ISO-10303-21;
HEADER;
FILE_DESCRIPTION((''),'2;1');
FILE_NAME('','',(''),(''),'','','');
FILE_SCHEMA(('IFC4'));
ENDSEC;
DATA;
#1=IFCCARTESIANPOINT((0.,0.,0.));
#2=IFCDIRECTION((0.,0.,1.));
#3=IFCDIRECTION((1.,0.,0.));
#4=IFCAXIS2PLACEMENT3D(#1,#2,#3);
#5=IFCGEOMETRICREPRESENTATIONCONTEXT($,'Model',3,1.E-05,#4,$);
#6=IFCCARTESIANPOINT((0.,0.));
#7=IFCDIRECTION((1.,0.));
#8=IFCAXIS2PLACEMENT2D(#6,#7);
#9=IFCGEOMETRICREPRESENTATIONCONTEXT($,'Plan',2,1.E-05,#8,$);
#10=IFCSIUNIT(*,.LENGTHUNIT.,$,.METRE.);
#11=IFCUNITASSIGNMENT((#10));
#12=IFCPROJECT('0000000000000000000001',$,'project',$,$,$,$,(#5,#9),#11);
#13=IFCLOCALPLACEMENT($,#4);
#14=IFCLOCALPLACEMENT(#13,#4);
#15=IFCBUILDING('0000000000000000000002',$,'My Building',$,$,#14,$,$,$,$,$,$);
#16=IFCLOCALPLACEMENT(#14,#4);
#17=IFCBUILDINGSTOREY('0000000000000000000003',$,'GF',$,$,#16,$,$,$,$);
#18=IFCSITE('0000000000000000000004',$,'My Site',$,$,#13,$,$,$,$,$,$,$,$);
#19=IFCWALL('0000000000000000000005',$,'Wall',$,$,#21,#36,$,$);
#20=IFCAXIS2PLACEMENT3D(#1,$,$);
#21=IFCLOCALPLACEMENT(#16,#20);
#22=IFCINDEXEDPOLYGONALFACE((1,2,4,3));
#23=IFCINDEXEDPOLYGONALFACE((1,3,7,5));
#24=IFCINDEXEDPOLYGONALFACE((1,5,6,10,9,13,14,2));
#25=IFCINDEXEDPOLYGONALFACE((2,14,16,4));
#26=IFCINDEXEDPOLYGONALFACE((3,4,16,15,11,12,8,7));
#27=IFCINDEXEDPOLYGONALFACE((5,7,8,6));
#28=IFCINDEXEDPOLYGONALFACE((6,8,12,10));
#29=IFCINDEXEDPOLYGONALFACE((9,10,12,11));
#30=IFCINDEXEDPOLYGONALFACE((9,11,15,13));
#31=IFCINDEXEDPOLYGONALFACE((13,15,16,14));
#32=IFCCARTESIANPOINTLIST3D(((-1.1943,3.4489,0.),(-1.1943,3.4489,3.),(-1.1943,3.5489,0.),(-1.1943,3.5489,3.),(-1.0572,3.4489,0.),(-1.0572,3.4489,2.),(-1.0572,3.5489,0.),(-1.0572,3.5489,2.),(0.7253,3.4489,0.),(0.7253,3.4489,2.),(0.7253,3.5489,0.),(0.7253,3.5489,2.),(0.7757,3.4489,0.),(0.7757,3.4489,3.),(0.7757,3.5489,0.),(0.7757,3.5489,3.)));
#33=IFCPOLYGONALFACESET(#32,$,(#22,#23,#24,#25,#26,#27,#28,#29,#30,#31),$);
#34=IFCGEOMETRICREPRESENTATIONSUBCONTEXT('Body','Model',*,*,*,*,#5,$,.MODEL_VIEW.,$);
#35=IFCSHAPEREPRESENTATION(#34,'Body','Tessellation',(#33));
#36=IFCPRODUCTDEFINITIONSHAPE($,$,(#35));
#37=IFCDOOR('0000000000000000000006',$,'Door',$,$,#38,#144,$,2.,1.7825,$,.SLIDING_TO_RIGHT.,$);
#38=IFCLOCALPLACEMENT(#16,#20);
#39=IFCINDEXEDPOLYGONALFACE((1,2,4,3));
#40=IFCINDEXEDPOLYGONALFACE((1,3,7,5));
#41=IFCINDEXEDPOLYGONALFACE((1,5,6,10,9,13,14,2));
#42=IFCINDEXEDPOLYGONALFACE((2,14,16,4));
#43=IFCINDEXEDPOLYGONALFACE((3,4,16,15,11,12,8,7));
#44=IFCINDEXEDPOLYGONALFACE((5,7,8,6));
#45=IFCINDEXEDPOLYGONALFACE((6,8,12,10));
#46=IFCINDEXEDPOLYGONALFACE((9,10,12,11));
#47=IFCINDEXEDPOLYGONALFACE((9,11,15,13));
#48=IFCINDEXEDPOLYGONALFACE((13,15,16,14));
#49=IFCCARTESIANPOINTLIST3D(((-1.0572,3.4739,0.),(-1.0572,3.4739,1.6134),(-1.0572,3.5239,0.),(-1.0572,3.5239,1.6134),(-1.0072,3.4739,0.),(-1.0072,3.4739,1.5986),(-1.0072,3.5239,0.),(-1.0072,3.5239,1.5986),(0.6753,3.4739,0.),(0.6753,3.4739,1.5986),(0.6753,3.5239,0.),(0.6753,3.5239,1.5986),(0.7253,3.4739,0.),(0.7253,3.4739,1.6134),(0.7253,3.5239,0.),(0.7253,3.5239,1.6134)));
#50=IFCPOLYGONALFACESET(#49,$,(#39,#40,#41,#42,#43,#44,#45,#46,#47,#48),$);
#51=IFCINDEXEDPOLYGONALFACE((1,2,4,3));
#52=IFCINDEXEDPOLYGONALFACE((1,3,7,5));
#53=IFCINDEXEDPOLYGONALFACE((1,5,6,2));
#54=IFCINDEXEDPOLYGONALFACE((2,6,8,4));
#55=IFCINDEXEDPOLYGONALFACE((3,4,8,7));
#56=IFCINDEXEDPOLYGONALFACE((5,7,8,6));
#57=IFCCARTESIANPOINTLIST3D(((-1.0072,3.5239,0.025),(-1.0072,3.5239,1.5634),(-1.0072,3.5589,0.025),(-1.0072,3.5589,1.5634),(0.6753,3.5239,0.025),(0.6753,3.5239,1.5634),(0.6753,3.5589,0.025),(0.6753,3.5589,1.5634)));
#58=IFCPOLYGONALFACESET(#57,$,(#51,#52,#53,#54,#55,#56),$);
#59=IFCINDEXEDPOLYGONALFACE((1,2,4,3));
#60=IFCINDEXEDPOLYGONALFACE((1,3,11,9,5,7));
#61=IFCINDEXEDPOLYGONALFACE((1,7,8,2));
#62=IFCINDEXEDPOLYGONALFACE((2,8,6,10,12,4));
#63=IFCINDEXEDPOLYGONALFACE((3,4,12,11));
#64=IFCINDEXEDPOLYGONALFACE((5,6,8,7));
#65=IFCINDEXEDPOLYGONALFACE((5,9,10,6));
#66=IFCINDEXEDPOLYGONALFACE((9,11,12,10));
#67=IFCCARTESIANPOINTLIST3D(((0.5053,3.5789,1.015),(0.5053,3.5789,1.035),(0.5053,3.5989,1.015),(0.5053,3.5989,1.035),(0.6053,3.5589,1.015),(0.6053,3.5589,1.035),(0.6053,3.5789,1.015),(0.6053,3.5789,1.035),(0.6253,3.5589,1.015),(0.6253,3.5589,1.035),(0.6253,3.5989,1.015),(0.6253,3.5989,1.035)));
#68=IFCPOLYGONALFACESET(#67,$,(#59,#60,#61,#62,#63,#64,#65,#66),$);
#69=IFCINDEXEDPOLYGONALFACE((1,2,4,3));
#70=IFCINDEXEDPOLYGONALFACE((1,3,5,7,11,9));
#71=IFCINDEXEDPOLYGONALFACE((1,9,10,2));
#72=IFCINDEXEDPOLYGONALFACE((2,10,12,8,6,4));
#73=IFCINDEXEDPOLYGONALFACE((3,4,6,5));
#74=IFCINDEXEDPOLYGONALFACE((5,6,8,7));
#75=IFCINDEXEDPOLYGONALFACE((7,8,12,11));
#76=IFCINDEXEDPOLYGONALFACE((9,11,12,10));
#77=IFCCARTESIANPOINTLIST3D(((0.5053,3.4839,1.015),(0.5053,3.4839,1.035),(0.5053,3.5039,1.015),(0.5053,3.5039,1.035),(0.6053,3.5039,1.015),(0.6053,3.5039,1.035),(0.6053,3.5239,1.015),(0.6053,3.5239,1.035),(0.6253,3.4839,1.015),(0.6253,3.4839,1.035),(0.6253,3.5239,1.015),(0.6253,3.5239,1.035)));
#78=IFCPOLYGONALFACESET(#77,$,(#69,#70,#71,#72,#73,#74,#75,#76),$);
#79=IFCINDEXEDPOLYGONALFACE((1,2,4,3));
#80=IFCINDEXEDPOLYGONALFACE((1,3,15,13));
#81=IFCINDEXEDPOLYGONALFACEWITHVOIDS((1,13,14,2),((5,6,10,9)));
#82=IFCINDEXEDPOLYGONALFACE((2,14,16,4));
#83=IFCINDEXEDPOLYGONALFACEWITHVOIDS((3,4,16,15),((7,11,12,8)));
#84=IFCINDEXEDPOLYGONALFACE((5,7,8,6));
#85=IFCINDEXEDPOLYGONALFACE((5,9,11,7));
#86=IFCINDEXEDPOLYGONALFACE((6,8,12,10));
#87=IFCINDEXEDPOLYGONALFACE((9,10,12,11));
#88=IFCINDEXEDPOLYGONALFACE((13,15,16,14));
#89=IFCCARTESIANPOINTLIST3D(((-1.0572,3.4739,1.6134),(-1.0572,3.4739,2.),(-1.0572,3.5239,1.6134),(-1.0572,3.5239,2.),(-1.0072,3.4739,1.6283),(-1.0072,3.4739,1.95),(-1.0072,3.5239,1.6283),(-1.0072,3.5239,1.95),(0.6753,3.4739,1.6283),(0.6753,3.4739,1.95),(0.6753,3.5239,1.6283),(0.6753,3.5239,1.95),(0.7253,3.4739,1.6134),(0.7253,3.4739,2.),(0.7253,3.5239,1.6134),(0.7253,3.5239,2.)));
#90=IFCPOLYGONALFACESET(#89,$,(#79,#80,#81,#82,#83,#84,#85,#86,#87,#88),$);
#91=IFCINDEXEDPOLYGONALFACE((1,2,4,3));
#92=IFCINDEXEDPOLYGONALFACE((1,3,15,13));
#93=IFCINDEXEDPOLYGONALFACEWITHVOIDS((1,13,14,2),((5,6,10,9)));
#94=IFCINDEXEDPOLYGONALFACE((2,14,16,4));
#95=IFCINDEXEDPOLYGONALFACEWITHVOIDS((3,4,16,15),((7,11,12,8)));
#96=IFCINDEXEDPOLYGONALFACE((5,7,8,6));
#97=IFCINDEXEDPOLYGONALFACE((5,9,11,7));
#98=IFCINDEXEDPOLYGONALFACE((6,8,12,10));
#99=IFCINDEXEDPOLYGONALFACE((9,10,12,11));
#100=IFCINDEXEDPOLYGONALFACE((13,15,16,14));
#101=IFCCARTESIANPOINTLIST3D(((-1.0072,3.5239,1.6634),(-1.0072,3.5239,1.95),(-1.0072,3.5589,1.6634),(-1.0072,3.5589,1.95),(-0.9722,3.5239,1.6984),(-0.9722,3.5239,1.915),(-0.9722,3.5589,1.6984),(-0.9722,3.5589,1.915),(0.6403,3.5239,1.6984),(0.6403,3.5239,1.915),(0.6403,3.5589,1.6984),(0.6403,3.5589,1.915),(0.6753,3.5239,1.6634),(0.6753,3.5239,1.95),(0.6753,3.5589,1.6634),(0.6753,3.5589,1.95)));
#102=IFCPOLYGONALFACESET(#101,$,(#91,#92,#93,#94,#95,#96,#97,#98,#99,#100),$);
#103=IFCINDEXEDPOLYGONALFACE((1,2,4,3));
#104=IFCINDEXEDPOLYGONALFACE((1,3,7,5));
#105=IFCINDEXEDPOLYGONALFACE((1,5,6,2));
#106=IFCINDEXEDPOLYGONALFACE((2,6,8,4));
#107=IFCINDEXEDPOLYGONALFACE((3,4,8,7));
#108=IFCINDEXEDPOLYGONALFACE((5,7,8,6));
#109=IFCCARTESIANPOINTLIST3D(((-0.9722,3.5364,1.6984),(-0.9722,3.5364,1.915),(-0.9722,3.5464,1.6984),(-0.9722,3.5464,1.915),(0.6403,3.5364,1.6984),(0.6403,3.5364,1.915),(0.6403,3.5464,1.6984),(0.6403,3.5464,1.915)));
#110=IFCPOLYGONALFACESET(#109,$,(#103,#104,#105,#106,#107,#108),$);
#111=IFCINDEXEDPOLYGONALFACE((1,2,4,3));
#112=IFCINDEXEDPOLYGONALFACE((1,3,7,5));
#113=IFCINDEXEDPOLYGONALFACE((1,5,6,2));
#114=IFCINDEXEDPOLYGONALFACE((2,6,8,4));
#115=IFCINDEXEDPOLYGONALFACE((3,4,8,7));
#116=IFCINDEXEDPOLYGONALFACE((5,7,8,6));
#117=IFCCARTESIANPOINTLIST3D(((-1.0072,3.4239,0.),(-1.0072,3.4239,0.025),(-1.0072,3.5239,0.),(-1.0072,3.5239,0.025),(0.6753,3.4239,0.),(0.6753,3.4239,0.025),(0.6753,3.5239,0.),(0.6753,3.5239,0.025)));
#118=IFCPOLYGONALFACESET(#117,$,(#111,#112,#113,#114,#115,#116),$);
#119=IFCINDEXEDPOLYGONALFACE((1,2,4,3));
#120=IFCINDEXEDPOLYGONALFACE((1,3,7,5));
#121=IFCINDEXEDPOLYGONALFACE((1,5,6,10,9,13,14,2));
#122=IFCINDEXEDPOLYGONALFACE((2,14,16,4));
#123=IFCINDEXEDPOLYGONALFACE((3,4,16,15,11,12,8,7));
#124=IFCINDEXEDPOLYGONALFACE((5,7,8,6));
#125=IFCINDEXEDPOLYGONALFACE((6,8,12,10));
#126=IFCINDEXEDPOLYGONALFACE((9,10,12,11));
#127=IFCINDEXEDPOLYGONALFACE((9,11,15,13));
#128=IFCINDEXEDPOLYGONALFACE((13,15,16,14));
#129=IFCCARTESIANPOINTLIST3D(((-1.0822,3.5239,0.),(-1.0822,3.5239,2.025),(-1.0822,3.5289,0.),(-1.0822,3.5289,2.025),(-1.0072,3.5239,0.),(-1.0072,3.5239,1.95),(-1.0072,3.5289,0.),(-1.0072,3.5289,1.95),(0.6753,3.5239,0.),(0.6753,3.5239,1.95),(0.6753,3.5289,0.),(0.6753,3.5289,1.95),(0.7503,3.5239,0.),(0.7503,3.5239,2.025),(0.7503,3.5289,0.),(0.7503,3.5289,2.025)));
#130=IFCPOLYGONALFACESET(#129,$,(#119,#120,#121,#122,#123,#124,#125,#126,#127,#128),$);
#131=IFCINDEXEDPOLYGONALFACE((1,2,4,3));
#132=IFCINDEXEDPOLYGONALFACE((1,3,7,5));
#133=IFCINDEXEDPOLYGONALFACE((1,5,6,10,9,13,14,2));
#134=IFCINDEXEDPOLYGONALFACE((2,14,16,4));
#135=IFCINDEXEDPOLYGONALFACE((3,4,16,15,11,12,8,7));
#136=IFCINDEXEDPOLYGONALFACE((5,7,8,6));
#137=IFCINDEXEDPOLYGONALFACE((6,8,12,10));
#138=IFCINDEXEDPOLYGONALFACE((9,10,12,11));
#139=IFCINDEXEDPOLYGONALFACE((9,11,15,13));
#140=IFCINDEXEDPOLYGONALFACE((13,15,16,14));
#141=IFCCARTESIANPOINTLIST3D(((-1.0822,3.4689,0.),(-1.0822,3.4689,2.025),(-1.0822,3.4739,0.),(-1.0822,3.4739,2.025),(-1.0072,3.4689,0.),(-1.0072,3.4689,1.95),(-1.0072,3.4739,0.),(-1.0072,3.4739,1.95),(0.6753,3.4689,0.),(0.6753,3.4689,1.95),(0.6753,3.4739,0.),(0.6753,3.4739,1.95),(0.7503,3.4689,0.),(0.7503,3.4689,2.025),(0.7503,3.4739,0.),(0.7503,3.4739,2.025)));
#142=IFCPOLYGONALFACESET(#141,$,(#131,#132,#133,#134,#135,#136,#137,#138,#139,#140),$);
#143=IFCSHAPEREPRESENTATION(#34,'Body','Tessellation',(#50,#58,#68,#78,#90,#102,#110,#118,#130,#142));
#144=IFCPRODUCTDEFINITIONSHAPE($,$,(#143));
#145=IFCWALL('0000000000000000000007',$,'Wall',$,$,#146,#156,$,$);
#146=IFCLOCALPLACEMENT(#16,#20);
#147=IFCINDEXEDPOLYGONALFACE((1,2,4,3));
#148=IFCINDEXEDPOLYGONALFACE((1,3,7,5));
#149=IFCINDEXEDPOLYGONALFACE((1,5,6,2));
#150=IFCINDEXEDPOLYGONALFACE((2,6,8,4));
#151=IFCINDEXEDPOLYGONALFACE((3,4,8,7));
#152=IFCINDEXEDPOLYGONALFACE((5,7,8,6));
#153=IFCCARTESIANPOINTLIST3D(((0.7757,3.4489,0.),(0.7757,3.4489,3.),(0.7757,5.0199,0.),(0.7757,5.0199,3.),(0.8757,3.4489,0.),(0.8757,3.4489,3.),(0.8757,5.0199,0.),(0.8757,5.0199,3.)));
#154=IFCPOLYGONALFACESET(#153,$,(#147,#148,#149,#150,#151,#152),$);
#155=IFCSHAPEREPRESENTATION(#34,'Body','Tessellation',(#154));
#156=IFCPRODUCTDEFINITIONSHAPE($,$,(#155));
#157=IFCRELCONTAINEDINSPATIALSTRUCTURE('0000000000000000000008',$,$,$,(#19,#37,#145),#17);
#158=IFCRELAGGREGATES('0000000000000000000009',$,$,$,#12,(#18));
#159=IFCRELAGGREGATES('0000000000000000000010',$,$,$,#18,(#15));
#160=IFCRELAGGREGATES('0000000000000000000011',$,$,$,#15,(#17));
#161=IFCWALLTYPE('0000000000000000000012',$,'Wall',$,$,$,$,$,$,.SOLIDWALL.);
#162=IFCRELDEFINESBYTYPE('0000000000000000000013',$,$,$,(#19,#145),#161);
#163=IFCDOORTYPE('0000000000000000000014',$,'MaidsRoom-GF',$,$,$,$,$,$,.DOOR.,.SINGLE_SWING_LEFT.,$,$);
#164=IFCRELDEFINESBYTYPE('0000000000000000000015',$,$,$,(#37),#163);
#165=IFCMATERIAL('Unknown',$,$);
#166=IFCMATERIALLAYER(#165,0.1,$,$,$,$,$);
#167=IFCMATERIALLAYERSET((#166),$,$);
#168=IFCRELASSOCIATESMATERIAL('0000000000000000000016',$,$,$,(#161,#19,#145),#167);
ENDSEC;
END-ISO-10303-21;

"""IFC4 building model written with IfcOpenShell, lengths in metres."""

from ifc_helpers import new_model, entity, si_unit, frame, origin_with_axes, origin_2d_with_axis, place, context, subcontext, project, spatial, line, indexed_curve, outline, extrude, shape, source, transform, mapped, material, layer, layer_set, layer_usage, type_object, type_shapes, element, fill, save


model = new_model("IFC4")

# Units and contexts
model_context = context("Model", 3, precision=1e-05, world=origin_with_axes())
plan_context = context("Plan", 2, precision=1e-05, world=origin_2d_with_axis())
body_context_1 = subcontext(model_context, "Body", "Model", "MODEL_VIEW")
body_context_2 = subcontext(plan_context, "Body", "Plan", "PLAN_VIEW")
ifc_project = project(units=[si_unit("LENGTHUNIT", "METRE")], contexts=[model_context, plan_context])

# Site, building, storey
site_placement = place(None, origin_with_axes())
site = spatial("IfcSite", under=ifc_project, at=site_placement, Name="My Site")
building_placement = place(site_placement, origin_with_axes())
building = spatial("IfcBuilding", under=site, at=building_placement, Name="My Building")
storey_placement = place(building_placement, origin_with_axes())
storey = spatial("IfcBuildingStorey", under=building, at=storey_placement, Name="GF")

# Shared definitions
ifc_material_1 = material(Name="Unknown")

# Shared definitions
ifc_layer_1 = layer(ifc_material_1, 0.1)
ifc_layer_set_1 = layer_set([ifc_layer_1])
wall_type = type_object("IfcWallType", Name="Wall", PredefinedType="SOLIDWALL", material=ifc_layer_set_1)

# Wall, opening, door
ifc_layer_usage_1 = layer_usage(ifc_layer_set_1, "AXIS2", "POSITIVE", 0.0)
wall_1_placement = place(storey_placement, frame((0.7757, 3.5489, 0.0), z_axis=(0.0, 0.0, 1.0), x_axis=(-1.0, 0.0, 0.0)))
wall_1 = element("IfcWall", 1, at=wall_1_placement, inside=storey, type_object=wall_type, material=ifc_layer_usage_1, Name="Wall", context=body_context_1, shape_type="SweptSolid", body=[
    extrude(outline(indexed_curve([(0.0, 0.0), (0.0, 0.1), (1.97, 0.1), (1.97, 0.0)], segments=[line(1, 2, 3, 4, 1)])), origin_with_axes(), (0.0, 0.0, 1.0), 3.0),
])
shared_shape_1 = source(origin_with_axes(), body_context_1, "Body", "SweptSolid", [
    extrude(outline(indexed_curve([(0.0, 0.0), (1.7825, 0.0), (1.7825, 2.0), (0.0, 2.0)], segments=[line(1, 2, 3, 4, 1)])), frame((0.0, -0.6, 0.0), z_axis=(0.0, -1.0, 0.0), x_axis=(1.0, 0.0, 0.0)), (0.0, 0.0, -1.0), 1.2),
])
opening_1_placement = place(wall_1_placement, frame((0.0505, 0.025, 0.0), z_axis=(0.0, 0.0, 1.0), x_axis=(1.0, -0.000001, 0.0)))
opening_1 = element("IfcOpeningElement", 2, at=opening_1_placement, cuts=wall_1, PredefinedType="OPENING", context=body_context_1, shape_type="MappedRepresentation", body=[
    mapped(shared_shape_1, transform((0.0, 0.0, 0.0), x_axis=(1.0, 0.0, 0.0), y_axis=(0.0, 1.0, 0.0), z_axis=(0.0, 0.0, 1.0), scale=1.0)),
])
door_type = type_object("IfcDoorType", Name="MaidsRoom-GF", OperationType="SINGLE_SWING_LEFT", PredefinedType="DOOR")
shared_shape_2 = source(origin_with_axes(), body_context_1, "Body", "SweptSolid", [
    extrude(outline(indexed_curve([(0.0, 0.0), (0.0, 1.6134), (1.7825, 1.6134), (1.7825, 0.0), (1.7325, 0.0), (1.7325, 1.5986), (0.05, 1.5986), (0.05, 0.0)], segments=[line(1, 2, 3, 4, 5, 6, 7, 8, 1)])), frame((0.0, 0.0, 0.0), z_axis=(0.0, -1.0, 0.0), x_axis=(1.0, 0.0, 0.0)), (0.0, 0.0, -1.0), 0.05),
    extrude(outline(indexed_curve([(0.0, 0.0), (1.6825, 0.0), (1.6825, 0.035), (0.0, 0.035)], segments=[line(1, 2, 3, 4, 1)])), frame((0.05, -0.035, 0.025), z_axis=(0.0, 0.0, 1.0), x_axis=(1.0, 0.0, 0.0)), (0.0, 0.0, 1.0), 1.5384),
    extrude(outline(indexed_curve([(0.0, 0.0), (0.0, -0.04), (0.12, -0.04), (0.12, -0.02), (0.02, -0.02), (0.02, 0.0)], segments=[line(1, 2, 3, 4, 5, 6, 1)])), frame((0.1, -0.035, 1.015), z_axis=(0.0, 0.0, 1.0), x_axis=(1.0, 0.0, 0.0)), (0.0, 0.0, 1.0), 0.02),
    extrude(outline(indexed_curve([(0.0, 0.0), (0.0, 0.04), (0.12, 0.04), (0.12, 0.02), (0.02, 0.02), (0.02, 0.0)], segments=[line(1, 2, 3, 4, 5, 6, 1)])), frame((0.1, 0.0, 1.015), z_axis=(0.0, 0.0, 1.0), x_axis=(1.0, 0.0, 0.0)), (0.0, 0.0, 1.0), 0.02),
    extrude(outline(indexed_curve([(0.0, 0.0), (1.7825, 0.0), (1.7825, 0.3866), (0.0, 0.3866)], segments=[line(1, 2, 3, 4, 1)]), holes=[indexed_curve([(0.05, 0.0148), (1.7325, 0.0148), (1.7325, 0.3366), (0.05, 0.3366)], segments=[line(1, 2, 3, 4, 1)])]), frame((0.0, 0.0, 1.6134), z_axis=(0.0, -1.0, 0.0), x_axis=(1.0, 0.0, 0.0)), (0.0, 0.0, -1.0), 0.05),
    extrude(outline(indexed_curve([(0.0, 0.0), (1.6825, 0.0), (1.6825, 0.2866), (0.0, 0.2866)], segments=[line(1, 2, 3, 4, 1)]), holes=[indexed_curve([(0.035, 0.035), (1.6475, 0.035), (1.6475, 0.2516), (0.035, 0.2516)], segments=[line(1, 2, 3, 4, 1)])]), frame((0.05, -0.035, 1.6634), z_axis=(0.0, -1.0, 0.0), x_axis=(1.0, 0.0, 0.0)), (0.0, 0.0, -1.0), 0.035),
    extrude(outline(indexed_curve([(0.035, 0.035), (1.6475, 0.035), (1.6475, 0.2516), (0.035, 0.2516)], segments=[line(1, 2, 3, 4, 1)])), frame((0.05, -0.0225, 1.6634), z_axis=(0.0, -1.0, 0.0), x_axis=(1.0, 0.0, 0.0)), (0.0, 0.0, -1.0), 0.01),
    extrude(outline(indexed_curve([(0.0, 0.0), (1.6825, 0.0), (1.6825, 0.1), (0.0, 0.1)], segments=[line(1, 2, 3, 4, 1)])), frame((0.05, 0.0, 0.0), z_axis=(0.0, 0.0, 1.0), x_axis=(1.0, 0.0, 0.0)), (0.0, 0.0, 1.0), 0.025),
    extrude(outline(indexed_curve([(0.0, 0.0), (0.0, 2.025), (1.8325, 2.025), (1.8325, 0.0), (1.7575, 0.0), (1.7575, 1.95), (0.075, 1.95), (0.075, 0.0)], segments=[line(1, 2, 3, 4, 5, 6, 7, 8, 1)])), frame((-0.025, -0.005, 0.0), z_axis=(0.0, -1.0, 0.0), x_axis=(1.0, 0.0, 0.0)), (0.0, 0.0, -1.0), 0.005),
    extrude(outline(indexed_curve([(0.0, 0.0), (0.0, 2.025), (1.8325, 2.025), (1.8325, 0.0), (1.7575, 0.0), (1.7575, 1.95), (0.075, 1.95), (0.075, 0.0)], segments=[line(1, 2, 3, 4, 5, 6, 7, 8, 1)])), frame((-0.025, 0.05, 0.0), z_axis=(0.0, -1.0, 0.0), x_axis=(1.0, 0.0, 0.0)), (0.0, 0.0, -1.0), 0.005),
])
shared_shape_3 = source(origin_with_axes(), body_context_2, "Body", "Curve2D", [
    entity("IfcIndexedPolyCurve", entity("IfcCartesianPointList2D", [[0.0, 0.0], [0.05, 0.0], [0.05, 0.05], [0.0, 0.05]]), [entity("IfcLineIndex", [1, 2, 3, 4, 1])]),
    entity("IfcIndexedPolyCurve", entity("IfcCartesianPointList2D", [[1.7825, 0.0], [1.7325, 0.0], [1.7325, 0.05], [1.7825, 0.05]]), [entity("IfcLineIndex", [1, 2, 3, 4, 1])]),
    entity("IfcIndexedPolyCurve", entity("IfcCartesianPointList2D", [[2.5737, -0.035], [0.8912, -0.035], [0.8912, 0.0], [2.5737, 0.0]]), [entity("IfcLineIndex", [1, 2, 3, 4, 1])]),
])
type_shapes(door_type, [shared_shape_2, shared_shape_3])
door_placement = place(opening_1_placement, frame((0.0, 0.0, 0.0), z_axis=(0.0, 0.0, 1.0), x_axis=(1.0, 0.0, 0.0)))
door = element("IfcDoor", 3, at=door_placement, inside=storey, type_object=door_type, Name="Door", OperationType="SLIDING_TO_RIGHT", OverallHeight=2.0, OverallWidth=1.7825, shapes=[
    shape(body_context_1, "Body", "MappedRepresentation", [mapped(shared_shape_2, transform((0.0, 0.0, 0.0), x_axis=(1.0, 0.0, 0.0), y_axis=(0.0, 1.0, 0.0), z_axis=(0.0, 0.0, 1.0), scale=1.0))]),
    shape(body_context_2, "Body", "MappedRepresentation", [mapped(shared_shape_3, transform((0.0, 0.0, 0.0), x_axis=(1.0, 0.0, 0.0), y_axis=(0.0, 1.0, 0.0), z_axis=(0.0, 0.0, 1.0), scale=1.0))]),
])
fill(opening_1, door)

# Wall
ifc_layer_usage_2 = layer_usage(ifc_layer_set_1, "AXIS2", "POSITIVE", 0.0)
wall_2_placement = place(storey_placement, frame((0.7757, 5.0199, 0.0), z_axis=(0.0, 0.0, 1.0), x_axis=(0.0, -1.0, 0.0)))
element("IfcWall", 4, at=wall_2_placement, inside=storey, type_object=wall_type, material=ifc_layer_usage_2, Name="Wall", context=body_context_1, shape_type="SweptSolid", body=[
    extrude(outline(indexed_curve([(0.0, 0.0), (0.0, 0.1), (1.571, 0.1), (1.571, 0.0)], segments=[line(1, 2, 3, 4, 1)])), origin_with_axes(), (0.0, 0.0, 1.0), 3.0),
])

save(model, "model.ifc")
